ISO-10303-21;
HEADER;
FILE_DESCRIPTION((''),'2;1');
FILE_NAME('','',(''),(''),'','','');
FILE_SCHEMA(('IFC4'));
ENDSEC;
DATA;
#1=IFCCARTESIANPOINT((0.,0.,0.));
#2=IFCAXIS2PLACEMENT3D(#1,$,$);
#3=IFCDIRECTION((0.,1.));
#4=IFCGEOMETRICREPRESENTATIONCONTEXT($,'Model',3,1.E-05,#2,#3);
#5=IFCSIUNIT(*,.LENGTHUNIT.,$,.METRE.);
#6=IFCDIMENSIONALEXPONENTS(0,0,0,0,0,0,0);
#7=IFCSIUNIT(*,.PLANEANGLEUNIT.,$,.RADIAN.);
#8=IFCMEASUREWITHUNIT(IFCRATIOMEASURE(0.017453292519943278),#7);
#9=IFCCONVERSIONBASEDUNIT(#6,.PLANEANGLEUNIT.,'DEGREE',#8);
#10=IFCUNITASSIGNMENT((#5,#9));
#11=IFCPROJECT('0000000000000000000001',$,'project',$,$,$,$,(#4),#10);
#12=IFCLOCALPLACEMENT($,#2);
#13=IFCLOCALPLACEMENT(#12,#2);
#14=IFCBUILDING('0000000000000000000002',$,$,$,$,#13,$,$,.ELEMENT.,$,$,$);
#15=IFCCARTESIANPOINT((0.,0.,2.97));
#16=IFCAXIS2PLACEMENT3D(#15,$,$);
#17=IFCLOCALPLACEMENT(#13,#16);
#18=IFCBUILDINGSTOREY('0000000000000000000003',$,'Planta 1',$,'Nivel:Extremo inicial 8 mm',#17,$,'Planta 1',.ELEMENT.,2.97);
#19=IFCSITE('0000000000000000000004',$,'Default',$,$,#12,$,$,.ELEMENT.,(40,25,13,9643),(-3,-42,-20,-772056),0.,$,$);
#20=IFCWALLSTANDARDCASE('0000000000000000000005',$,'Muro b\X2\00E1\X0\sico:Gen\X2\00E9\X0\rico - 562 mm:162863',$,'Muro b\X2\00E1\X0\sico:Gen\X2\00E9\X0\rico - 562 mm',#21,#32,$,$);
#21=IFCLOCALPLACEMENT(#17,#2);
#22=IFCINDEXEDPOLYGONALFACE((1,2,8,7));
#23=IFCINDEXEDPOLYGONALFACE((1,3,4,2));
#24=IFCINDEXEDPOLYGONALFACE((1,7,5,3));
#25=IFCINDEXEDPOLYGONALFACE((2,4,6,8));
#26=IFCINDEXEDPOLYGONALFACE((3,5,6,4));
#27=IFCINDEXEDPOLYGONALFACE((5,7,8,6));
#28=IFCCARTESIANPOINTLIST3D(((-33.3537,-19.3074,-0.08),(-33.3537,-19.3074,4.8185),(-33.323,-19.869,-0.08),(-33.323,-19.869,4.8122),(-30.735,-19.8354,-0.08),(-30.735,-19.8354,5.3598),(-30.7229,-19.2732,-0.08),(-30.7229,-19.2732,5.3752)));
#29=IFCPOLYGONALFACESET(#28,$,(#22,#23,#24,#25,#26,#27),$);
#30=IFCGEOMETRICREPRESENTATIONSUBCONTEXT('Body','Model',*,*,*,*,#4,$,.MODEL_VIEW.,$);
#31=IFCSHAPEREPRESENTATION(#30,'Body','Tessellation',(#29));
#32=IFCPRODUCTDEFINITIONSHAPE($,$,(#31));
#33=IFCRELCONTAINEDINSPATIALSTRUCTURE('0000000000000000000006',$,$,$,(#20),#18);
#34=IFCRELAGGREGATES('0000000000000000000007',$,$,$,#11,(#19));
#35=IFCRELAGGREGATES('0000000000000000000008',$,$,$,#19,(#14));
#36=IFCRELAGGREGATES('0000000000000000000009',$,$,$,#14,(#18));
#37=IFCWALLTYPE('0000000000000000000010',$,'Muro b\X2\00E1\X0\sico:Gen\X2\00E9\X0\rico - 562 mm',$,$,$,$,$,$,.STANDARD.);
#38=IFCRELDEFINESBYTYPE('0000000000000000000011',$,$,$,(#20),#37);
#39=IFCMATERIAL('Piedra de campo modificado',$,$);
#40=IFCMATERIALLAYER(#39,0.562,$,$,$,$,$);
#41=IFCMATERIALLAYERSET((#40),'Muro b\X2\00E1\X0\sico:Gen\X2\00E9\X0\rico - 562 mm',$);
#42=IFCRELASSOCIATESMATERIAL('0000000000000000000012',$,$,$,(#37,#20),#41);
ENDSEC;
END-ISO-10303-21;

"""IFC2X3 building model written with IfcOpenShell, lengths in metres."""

from ifc_helpers import new_model, entity, si_unit, converted_unit, direction, frame, origin, place, context, subcontext, project, spatial, polyline, outline, extrude, clip, bounded_halfspace, material, layer, layer_set, layer_usage, type_object, element, save


model = new_model("IFC2X3")

# Units and contexts
model_context = context("Model", 3, precision=1e-05, world=origin(), true_north=direction((0.0, 1.0)))
body_context = subcontext(model_context, "Body", "Model", "MODEL_VIEW")
ifc_project = project(units=[si_unit("LENGTHUNIT", "METRE"), converted_unit("PLANEANGLEUNIT", "DEGREE", entity("IfcRatioMeasure", 0.017453292519943278), si_unit("PLANEANGLEUNIT", "RADIAN"), dimensions=[0, 0, 0, 0, 0, 0, 0])], contexts=[model_context])

# Site, building, storey
site_placement = place(None, origin())
site = spatial("IfcSite", under=ifc_project, at=site_placement, Name="Default", CompositionType="ELEMENT", RefLatitude=(40, 25, 13, 9643), RefLongitude=(-3, -42, -20, -772056), RefElevation=0.0)
building_placement = place(site_placement, origin())
building = spatial("IfcBuilding", under=site, at=building_placement, CompositionType="ELEMENT")
storey_placement = place(building_placement, frame((0.0, 0.0, 2.97)))
storey = spatial("IfcBuildingStorey", under=building, at=storey_placement, Name="Planta 1", ObjectType="Nivel:Extremo inicial 8 mm", LongName="Planta 1", CompositionType="ELEMENT", Elevation=2.97)

# Wall
ifc_material_1 = material(Name="Piedra de campo modificado")
ifc_layer_1 = layer(ifc_material_1, 0.562)
ifc_layer_set_1 = layer_set([ifc_layer_1], Name="Muro básico:Genérico - 562 mm")
ifc_layer_usage_1 = layer_usage(ifc_layer_set_1, "AXIS2", "NEGATIVE", 0.281)
wall_type = type_object("IfcWallType", Name="Muro básico:Genérico - 562 mm", PredefinedType="STANDARD", material=ifc_layer_set_1)
wall_placement = place(storey_placement, frame((-33.3501, -19.5883, -0.08), z_axis=(0.0, 0.0, 1.0), x_axis=(0.999916, 0.01299, 0.0)))
element("IfcWallStandardCase", 1, at=wall_placement, inside=storey, type_object=wall_type, material=ifc_layer_usage_1, Name="Muro básico:Genérico - 562 mm:162863", ObjectType="Muro básico:Genérico - 562 mm", context=body_context, shape_type="Clipping", body=[
    clip(extrude(outline(polyline([(2.6116, -0.281), (2.631, 0.281), (0.0, 0.281), (0.0234, -0.281), (2.6116, -0.281)])), origin(), (0.0, 0.0, 1.0), 5.4552), bounded_halfspace(frame((0.0234, -0.281, 4.8922), z_axis=(-0.206975, -0.019717, 0.978148), x_axis=(0.094836, -0.995493, 0.0)), False, frame((0.0234, -0.281, 4.8922)), polyline([(0.0, 0.0), (2.5882, 0.0), (2.6076, 0.562), (-0.0234, 0.562), (0.0, 0.0)]))),
])

save(model, "model.ifc")
